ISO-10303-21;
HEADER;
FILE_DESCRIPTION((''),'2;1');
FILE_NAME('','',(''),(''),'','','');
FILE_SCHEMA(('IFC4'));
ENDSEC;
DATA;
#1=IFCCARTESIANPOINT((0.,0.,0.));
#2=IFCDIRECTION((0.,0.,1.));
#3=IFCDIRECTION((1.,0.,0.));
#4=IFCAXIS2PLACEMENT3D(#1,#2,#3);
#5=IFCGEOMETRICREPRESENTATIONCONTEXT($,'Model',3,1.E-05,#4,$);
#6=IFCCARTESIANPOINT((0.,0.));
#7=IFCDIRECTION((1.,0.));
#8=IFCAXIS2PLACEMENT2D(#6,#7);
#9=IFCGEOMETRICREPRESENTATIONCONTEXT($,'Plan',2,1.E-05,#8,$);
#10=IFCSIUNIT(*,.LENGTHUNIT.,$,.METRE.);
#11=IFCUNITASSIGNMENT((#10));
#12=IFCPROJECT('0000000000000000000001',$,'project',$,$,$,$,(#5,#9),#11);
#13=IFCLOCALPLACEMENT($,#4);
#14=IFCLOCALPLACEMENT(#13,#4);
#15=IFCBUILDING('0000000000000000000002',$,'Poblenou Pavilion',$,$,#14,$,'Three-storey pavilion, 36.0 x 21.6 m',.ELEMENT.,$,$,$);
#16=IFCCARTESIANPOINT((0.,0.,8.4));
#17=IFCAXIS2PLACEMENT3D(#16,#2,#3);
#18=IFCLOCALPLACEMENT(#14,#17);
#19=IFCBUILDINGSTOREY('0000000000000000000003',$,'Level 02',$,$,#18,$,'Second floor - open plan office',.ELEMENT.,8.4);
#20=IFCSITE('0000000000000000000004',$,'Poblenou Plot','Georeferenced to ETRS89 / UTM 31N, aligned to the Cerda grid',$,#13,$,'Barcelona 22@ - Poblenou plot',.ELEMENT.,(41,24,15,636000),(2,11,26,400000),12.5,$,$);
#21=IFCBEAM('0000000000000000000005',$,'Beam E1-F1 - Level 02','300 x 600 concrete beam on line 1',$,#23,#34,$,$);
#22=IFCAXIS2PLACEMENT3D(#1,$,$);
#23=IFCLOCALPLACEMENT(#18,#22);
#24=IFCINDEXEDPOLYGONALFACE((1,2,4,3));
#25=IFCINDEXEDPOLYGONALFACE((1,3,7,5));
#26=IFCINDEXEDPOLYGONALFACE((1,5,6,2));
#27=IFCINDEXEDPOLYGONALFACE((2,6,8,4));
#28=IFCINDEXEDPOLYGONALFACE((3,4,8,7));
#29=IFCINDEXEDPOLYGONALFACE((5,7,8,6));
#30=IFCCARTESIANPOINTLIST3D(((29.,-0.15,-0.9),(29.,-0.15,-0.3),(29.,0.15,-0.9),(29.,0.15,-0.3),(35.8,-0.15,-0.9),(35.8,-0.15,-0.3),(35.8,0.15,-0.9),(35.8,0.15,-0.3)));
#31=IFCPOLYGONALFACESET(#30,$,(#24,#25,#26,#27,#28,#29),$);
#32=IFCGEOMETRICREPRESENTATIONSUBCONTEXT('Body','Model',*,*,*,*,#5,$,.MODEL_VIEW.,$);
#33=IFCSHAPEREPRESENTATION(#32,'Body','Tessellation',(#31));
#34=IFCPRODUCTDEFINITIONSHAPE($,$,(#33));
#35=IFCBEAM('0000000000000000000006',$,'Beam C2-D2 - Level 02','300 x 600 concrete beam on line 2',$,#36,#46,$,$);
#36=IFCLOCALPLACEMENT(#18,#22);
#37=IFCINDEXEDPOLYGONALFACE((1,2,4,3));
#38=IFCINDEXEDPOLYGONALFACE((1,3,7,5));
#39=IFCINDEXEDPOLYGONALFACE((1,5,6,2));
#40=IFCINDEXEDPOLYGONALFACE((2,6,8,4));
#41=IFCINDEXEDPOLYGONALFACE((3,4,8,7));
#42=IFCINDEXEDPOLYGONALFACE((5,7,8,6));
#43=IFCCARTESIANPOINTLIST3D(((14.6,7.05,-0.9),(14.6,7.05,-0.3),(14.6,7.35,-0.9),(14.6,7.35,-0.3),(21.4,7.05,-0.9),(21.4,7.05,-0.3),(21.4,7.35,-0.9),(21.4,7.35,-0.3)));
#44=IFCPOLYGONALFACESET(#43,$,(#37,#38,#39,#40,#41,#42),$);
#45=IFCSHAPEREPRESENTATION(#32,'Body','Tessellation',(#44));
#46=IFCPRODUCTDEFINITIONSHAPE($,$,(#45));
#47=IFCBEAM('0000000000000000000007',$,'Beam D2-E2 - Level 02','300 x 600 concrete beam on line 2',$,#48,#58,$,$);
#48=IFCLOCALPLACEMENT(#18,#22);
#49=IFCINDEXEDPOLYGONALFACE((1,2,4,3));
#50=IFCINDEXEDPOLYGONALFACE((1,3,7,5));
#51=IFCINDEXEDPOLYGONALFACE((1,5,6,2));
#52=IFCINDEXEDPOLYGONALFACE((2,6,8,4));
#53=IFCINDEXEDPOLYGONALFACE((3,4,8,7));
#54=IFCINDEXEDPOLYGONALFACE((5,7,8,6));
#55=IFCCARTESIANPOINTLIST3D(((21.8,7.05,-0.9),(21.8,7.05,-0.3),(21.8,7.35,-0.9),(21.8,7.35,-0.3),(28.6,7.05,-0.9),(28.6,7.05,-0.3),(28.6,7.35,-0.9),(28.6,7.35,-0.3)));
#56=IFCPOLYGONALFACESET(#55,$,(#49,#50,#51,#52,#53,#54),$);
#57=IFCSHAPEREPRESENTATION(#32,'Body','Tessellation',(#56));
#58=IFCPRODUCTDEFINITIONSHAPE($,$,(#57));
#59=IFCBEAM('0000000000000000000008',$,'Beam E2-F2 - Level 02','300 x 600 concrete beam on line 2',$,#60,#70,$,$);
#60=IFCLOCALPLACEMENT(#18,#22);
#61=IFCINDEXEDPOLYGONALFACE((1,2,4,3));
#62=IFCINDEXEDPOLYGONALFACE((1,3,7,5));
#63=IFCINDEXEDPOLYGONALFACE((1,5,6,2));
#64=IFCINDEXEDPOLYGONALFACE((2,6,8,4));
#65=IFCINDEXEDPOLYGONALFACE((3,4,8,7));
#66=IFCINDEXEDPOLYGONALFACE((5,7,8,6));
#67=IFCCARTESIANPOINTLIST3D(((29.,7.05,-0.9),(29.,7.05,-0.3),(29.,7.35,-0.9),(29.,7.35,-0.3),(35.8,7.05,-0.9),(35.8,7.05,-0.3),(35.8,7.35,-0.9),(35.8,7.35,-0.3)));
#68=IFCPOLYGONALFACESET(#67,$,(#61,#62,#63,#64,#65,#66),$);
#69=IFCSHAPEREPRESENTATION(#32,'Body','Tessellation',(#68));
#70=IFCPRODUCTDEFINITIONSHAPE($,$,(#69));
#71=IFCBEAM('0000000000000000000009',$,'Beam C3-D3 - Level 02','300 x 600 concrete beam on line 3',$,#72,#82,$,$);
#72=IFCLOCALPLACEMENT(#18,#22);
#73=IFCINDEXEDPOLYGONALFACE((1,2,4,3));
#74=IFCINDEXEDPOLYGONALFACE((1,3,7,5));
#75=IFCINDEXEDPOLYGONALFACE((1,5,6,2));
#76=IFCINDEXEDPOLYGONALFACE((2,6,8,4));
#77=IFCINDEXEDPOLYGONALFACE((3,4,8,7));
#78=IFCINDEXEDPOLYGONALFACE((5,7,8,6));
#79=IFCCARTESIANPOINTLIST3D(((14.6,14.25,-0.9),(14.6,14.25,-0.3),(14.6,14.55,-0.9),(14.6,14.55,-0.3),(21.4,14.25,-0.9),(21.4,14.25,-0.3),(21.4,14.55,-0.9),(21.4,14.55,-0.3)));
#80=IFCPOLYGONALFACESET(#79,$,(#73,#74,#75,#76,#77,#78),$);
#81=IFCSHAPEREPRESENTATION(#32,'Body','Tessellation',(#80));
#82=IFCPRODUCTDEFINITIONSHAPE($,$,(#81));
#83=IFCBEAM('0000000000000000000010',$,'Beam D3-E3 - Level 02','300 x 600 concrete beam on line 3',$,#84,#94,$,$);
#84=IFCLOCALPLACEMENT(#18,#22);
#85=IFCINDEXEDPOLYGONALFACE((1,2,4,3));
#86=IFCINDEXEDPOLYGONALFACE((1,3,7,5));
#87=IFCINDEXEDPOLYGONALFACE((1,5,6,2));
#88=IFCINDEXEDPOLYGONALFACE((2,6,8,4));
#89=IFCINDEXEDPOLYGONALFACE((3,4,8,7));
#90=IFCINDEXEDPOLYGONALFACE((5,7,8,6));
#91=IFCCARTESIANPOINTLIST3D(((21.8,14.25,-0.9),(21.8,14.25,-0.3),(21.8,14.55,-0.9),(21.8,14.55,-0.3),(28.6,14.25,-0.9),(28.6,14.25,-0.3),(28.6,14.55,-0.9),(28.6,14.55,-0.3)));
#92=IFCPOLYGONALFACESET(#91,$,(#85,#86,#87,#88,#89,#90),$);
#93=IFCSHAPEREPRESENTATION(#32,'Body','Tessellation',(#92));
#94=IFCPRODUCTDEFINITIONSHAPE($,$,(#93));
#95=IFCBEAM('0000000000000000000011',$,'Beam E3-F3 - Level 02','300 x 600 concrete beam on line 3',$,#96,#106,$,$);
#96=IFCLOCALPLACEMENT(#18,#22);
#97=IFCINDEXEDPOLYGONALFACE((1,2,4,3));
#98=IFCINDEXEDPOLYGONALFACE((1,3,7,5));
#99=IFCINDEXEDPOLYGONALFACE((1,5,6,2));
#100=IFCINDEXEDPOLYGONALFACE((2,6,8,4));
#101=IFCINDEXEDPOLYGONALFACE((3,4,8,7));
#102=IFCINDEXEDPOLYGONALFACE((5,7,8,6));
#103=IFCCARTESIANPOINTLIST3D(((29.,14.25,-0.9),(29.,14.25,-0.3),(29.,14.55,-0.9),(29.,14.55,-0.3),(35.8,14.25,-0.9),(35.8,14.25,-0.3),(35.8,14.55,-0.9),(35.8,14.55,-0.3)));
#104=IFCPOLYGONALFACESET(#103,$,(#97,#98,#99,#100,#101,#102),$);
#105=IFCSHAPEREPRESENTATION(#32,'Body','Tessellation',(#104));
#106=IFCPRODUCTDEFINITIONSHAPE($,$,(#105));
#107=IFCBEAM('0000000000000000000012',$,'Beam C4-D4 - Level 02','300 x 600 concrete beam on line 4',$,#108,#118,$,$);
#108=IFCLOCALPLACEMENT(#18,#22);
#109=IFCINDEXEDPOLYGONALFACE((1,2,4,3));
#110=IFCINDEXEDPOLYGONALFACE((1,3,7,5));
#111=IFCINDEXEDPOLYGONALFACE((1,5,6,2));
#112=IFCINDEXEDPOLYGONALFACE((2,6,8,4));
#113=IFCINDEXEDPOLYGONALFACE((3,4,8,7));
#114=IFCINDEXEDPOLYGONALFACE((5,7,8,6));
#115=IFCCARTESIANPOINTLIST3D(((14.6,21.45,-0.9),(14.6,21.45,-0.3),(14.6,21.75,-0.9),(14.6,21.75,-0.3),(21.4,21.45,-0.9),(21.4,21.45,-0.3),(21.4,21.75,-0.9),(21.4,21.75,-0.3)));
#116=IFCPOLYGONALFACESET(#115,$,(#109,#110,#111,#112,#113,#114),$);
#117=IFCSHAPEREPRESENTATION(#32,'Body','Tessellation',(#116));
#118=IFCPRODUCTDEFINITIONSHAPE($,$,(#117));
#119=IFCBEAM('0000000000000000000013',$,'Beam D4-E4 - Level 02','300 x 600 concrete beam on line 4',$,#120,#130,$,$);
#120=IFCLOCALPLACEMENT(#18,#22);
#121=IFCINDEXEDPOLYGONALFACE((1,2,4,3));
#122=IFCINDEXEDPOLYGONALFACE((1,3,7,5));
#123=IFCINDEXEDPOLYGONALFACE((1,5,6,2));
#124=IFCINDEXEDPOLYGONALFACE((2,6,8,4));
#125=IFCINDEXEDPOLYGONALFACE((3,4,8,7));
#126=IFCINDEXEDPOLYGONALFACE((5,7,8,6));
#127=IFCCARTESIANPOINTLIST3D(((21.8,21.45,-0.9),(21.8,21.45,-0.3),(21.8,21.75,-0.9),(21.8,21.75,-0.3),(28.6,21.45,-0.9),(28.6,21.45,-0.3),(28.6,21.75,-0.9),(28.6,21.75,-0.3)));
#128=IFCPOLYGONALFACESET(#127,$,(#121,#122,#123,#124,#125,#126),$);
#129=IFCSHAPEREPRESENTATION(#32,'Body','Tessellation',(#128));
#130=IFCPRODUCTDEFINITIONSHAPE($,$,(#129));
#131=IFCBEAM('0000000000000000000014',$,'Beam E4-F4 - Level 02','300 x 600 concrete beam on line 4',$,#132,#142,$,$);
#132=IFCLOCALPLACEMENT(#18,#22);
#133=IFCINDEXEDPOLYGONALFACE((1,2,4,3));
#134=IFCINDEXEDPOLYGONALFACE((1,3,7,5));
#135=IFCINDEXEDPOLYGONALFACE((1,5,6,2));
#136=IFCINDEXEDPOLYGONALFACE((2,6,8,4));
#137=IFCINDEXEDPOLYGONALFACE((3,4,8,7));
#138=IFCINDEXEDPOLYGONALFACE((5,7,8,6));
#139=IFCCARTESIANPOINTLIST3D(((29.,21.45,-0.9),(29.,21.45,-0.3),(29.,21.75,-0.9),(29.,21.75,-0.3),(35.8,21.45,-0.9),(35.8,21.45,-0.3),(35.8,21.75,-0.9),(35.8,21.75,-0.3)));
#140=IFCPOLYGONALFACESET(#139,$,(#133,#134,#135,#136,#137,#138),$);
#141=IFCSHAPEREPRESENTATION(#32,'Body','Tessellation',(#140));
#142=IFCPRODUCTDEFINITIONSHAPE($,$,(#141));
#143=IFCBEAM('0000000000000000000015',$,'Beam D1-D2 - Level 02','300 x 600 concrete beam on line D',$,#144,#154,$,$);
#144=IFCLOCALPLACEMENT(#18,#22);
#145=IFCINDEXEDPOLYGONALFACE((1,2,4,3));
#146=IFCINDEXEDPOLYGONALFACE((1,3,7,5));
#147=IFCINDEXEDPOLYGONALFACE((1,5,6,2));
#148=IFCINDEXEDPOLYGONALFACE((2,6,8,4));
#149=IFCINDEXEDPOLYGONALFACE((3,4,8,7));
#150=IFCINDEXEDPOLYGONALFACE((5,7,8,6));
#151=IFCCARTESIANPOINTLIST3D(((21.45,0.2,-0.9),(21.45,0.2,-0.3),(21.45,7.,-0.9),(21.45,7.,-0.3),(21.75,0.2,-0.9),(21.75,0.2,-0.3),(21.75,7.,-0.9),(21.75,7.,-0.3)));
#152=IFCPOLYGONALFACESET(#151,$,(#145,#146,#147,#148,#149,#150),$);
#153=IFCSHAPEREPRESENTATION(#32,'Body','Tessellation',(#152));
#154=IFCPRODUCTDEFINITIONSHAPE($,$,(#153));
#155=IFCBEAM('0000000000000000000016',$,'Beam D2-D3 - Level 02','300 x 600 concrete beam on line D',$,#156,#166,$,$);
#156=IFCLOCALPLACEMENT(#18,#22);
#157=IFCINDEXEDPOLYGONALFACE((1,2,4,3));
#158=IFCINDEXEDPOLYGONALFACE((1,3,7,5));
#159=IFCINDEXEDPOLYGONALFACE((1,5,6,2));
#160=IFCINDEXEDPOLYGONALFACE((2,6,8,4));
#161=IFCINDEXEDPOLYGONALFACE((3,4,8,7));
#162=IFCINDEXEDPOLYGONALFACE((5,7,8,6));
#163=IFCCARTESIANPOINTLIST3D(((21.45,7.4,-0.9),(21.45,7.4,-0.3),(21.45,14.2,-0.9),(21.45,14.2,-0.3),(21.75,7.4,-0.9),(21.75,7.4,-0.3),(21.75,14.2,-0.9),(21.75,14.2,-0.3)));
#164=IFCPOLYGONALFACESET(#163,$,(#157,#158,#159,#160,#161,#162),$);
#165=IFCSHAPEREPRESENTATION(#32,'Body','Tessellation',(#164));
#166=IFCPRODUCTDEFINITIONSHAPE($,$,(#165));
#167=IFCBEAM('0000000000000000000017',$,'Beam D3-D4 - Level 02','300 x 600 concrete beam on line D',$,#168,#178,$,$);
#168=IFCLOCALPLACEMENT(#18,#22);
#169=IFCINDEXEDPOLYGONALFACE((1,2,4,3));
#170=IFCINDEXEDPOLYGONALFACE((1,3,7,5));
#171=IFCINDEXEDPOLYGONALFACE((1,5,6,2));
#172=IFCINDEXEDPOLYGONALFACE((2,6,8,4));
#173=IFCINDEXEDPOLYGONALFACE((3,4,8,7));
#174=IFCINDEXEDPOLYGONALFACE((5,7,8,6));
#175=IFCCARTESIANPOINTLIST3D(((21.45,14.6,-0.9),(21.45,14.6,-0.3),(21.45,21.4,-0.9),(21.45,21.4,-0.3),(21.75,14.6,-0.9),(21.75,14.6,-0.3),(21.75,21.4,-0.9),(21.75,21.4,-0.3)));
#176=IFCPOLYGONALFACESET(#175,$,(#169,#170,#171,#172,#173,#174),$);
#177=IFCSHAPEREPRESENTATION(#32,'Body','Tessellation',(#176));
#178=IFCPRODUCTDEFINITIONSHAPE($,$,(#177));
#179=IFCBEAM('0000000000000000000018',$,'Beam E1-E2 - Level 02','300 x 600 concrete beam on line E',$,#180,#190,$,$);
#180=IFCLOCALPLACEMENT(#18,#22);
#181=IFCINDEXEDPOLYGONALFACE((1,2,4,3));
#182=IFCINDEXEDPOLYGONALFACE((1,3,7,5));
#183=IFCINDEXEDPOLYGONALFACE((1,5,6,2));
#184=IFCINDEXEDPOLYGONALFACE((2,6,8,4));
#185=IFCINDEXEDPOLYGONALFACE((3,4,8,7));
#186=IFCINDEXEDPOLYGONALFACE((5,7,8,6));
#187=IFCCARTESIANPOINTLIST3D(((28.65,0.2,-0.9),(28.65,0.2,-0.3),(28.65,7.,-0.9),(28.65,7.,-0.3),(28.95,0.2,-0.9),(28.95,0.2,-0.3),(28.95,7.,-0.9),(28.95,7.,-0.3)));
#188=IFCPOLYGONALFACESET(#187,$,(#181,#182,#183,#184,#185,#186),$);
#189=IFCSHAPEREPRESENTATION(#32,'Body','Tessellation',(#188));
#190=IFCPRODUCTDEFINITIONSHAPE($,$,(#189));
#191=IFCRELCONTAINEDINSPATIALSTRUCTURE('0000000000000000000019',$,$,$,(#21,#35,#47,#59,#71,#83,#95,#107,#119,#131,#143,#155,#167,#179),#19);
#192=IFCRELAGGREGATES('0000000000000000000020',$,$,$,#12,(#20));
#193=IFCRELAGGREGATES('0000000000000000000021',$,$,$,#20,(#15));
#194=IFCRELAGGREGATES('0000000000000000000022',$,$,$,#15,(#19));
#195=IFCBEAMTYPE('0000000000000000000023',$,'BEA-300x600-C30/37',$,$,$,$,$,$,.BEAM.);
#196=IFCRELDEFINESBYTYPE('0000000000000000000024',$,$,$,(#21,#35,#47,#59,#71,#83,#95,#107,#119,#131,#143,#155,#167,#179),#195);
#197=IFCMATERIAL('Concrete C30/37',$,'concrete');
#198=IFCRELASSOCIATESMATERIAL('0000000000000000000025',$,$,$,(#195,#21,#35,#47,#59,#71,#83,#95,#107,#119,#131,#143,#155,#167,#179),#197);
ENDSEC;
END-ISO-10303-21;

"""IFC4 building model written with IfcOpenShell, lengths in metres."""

from ifc_helpers import new_model, si_unit, frame, origin_with_axes, origin_2d_with_axis, place, context, subcontext, project, spatial, line, indexed_curve, rectangle, outline, extrude, material, material_profile, profile_set, profile_usage, type_object, element, save


model = new_model("IFC4")

# Units and contexts
model_context = context("Model", 3, precision=1e-05, world=origin_with_axes())
plan_context = context("Plan", 2, precision=1e-05, world=origin_2d_with_axis())
body_context = subcontext(model_context, "Body", "Model", "MODEL_VIEW")
ifc_project = project(units=[si_unit("LENGTHUNIT", "METRE")], contexts=[model_context, plan_context])

# Site, building, storey
site_placement = place(None, origin_with_axes())
site = spatial("IfcSite", under=ifc_project, at=site_placement, Name="Poblenou Plot", Description="Georeferenced to ETRS89 / UTM 31N, aligned to the Cerda grid", LongName="Barcelona 22@ - Poblenou plot", CompositionType="ELEMENT", RefLatitude=(41, 24, 15, 636000), RefLongitude=(2, 11, 26, 400000), RefElevation=12.5)
building_placement = place(site_placement, origin_with_axes())
building = spatial("IfcBuilding", under=site, at=building_placement, Name="Poblenou Pavilion", LongName="Three-storey pavilion, 36.0 x 21.6 m", CompositionType="ELEMENT")
storey_placement = place(building_placement, frame((0.0, 0.0, 8.4), z_axis=(0.0, 0.0, 1.0), x_axis=(1.0, 0.0, 0.0)))
storey = spatial("IfcBuildingStorey", under=building, at=storey_placement, Name="Level 02", LongName="Second floor - open plan office", CompositionType="ELEMENT", Elevation=8.4)

# Shared definitions
ifc_material = material(Name="Concrete C30/37", Category="concrete")

# Beams
ifc_material_profile_1 = material_profile(ifc_material, rectangle(XDim=0.3, YDim=0.6))
ifc_profile_set_1 = profile_set([ifc_material_profile_1], Name="BEA-300x600-C30/37")
beam_type = type_object("IfcBeamType", Name="BEA-300x600-C30/37", PredefinedType="BEAM", material=ifc_profile_set_1)
ifc_profile_usage_1 = profile_usage(ifc_profile_set_1)
beam_1_placement = place(storey_placement, frame((29.0, -0.15, -0.9), z_axis=(1.0, 0.0, 0.0), x_axis=(0.0, 1.0, 0.0)))
element("IfcBeam", 1, at=beam_1_placement, inside=storey, type_object=beam_type, material=ifc_profile_usage_1, Name="Beam E1-F1 - Level 02", Description="300 x 600 concrete beam on line 1", context=body_context, shape_type="SweptSolid", body=[
    extrude(outline(indexed_curve([(0.0, 0.0), (0.3, 0.0), (0.3, 0.6), (0.0, 0.6)], segments=[line(1, 2, 3, 4, 1)])), origin_with_axes(), (0.0, 0.0, 1.0), 6.8),
])
ifc_profile_usage_2 = profile_usage(ifc_profile_set_1)
beam_2_placement = place(storey_placement, frame((14.6, 7.05, -0.9), z_axis=(1.0, 0.0, 0.0), x_axis=(0.0, 1.0, 0.0)))
element("IfcBeam", 2, at=beam_2_placement, inside=storey, type_object=beam_type, material=ifc_profile_usage_2, Name="Beam C2-D2 - Level 02", Description="300 x 600 concrete beam on line 2", context=body_context, shape_type="SweptSolid", body=[
    extrude(outline(indexed_curve([(0.0, 0.0), (0.3, 0.0), (0.3, 0.6), (0.0, 0.6)], segments=[line(1, 2, 3, 4, 1)])), origin_with_axes(), (0.0, 0.0, 1.0), 6.8),
])
ifc_profile_usage_3 = profile_usage(ifc_profile_set_1)
beam_3_placement = place(storey_placement, frame((21.8, 7.05, -0.9), z_axis=(1.0, 0.0, 0.0), x_axis=(0.0, 1.0, 0.0)))
element("IfcBeam", 3, at=beam_3_placement, inside=storey, type_object=beam_type, material=ifc_profile_usage_3, Name="Beam D2-E2 - Level 02", Description="300 x 600 concrete beam on line 2", context=body_context, shape_type="SweptSolid", body=[
    extrude(outline(indexed_curve([(0.0, 0.0), (0.3, 0.0), (0.3, 0.6), (0.0, 0.6)], segments=[line(1, 2, 3, 4, 1)])), origin_with_axes(), (0.0, 0.0, 1.0), 6.8),
])
ifc_profile_usage_4 = profile_usage(ifc_profile_set_1)
beam_4_placement = place(storey_placement, frame((29.0, 7.05, -0.9), z_axis=(1.0, 0.0, 0.0), x_axis=(0.0, 1.0, 0.0)))
element("IfcBeam", 4, at=beam_4_placement, inside=storey, type_object=beam_type, material=ifc_profile_usage_4, Name="Beam E2-F2 - Level 02", Description="300 x 600 concrete beam on line 2", context=body_context, shape_type="SweptSolid", body=[
    extrude(outline(indexed_curve([(0.0, 0.0), (0.3, 0.0), (0.3, 0.6), (0.0, 0.6)], segments=[line(1, 2, 3, 4, 1)])), origin_with_axes(), (0.0, 0.0, 1.0), 6.8),
])
ifc_profile_usage_5 = profile_usage(ifc_profile_set_1)
beam_5_placement = place(storey_placement, frame((14.6, 14.25, -0.9), z_axis=(1.0, 0.0, 0.0), x_axis=(0.0, 1.0, 0.0)))
element("IfcBeam", 5, at=beam_5_placement, inside=storey, type_object=beam_type, material=ifc_profile_usage_5, Name="Beam C3-D3 - Level 02", Description="300 x 600 concrete beam on line 3", context=body_context, shape_type="SweptSolid", body=[
    extrude(outline(indexed_curve([(0.0, 0.0), (0.3, 0.0), (0.3, 0.6), (0.0, 0.6)], segments=[line(1, 2, 3, 4, 1)])), origin_with_axes(), (0.0, 0.0, 1.0), 6.8),
])
ifc_profile_usage_6 = profile_usage(ifc_profile_set_1)
beam_6_placement = place(storey_placement, frame((21.8, 14.25, -0.9), z_axis=(1.0, 0.0, 0.0), x_axis=(0.0, 1.0, 0.0)))
element("IfcBeam", 6, at=beam_6_placement, inside=storey, type_object=beam_type, material=ifc_profile_usage_6, Name="Beam D3-E3 - Level 02", Description="300 x 600 concrete beam on line 3", context=body_context, shape_type="SweptSolid", body=[
    extrude(outline(indexed_curve([(0.0, 0.0), (0.3, 0.0), (0.3, 0.6), (0.0, 0.6)], segments=[line(1, 2, 3, 4, 1)])), origin_with_axes(), (0.0, 0.0, 1.0), 6.8),
])
ifc_profile_usage_7 = profile_usage(ifc_profile_set_1)
beam_7_placement = place(storey_placement, frame((29.0, 14.25, -0.9), z_axis=(1.0, 0.0, 0.0), x_axis=(0.0, 1.0, 0.0)))
element("IfcBeam", 7, at=beam_7_placement, inside=storey, type_object=beam_type, material=ifc_profile_usage_7, Name="Beam E3-F3 - Level 02", Description="300 x 600 concrete beam on line 3", context=body_context, shape_type="SweptSolid", body=[
    extrude(outline(indexed_curve([(0.0, 0.0), (0.3, 0.0), (0.3, 0.6), (0.0, 0.6)], segments=[line(1, 2, 3, 4, 1)])), origin_with_axes(), (0.0, 0.0, 1.0), 6.8),
])
ifc_profile_usage_8 = profile_usage(ifc_profile_set_1)
beam_8_placement = place(storey_placement, frame((14.6, 21.45, -0.9), z_axis=(1.0, 0.0, 0.0), x_axis=(0.0, 1.0, 0.0)))
element("IfcBeam", 8, at=beam_8_placement, inside=storey, type_object=beam_type, material=ifc_profile_usage_8, Name="Beam C4-D4 - Level 02", Description="300 x 600 concrete beam on line 4", context=body_context, shape_type="SweptSolid", body=[
    extrude(outline(indexed_curve([(0.0, 0.0), (0.3, 0.0), (0.3, 0.6), (0.0, 0.6)], segments=[line(1, 2, 3, 4, 1)])), origin_with_axes(), (0.0, 0.0, 1.0), 6.8),
])
ifc_profile_usage_9 = profile_usage(ifc_profile_set_1)
beam_9_placement = place(storey_placement, frame((21.8, 21.45, -0.9), z_axis=(1.0, 0.0, 0.0), x_axis=(0.0, 1.0, 0.0)))
element("IfcBeam", 9, at=beam_9_placement, inside=storey, type_object=beam_type, material=ifc_profile_usage_9, Name="Beam D4-E4 - Level 02", Description="300 x 600 concrete beam on line 4", context=body_context, shape_type="SweptSolid", body=[
    extrude(outline(indexed_curve([(0.0, 0.0), (0.3, 0.0), (0.3, 0.6), (0.0, 0.6)], segments=[line(1, 2, 3, 4, 1)])), origin_with_axes(), (0.0, 0.0, 1.0), 6.8),
])
ifc_profile_usage_10 = profile_usage(ifc_profile_set_1)
beam_10_placement = place(storey_placement, frame((29.0, 21.45, -0.9), z_axis=(1.0, 0.0, 0.0), x_axis=(0.0, 1.0, 0.0)))
element("IfcBeam", 10, at=beam_10_placement, inside=storey, type_object=beam_type, material=ifc_profile_usage_10, Name="Beam E4-F4 - Level 02", Description="300 x 600 concrete beam on line 4", context=body_context, shape_type="SweptSolid", body=[
    extrude(outline(indexed_curve([(0.0, 0.0), (0.3, 0.0), (0.3, 0.6), (0.0, 0.6)], segments=[line(1, 2, 3, 4, 1)])), origin_with_axes(), (0.0, 0.0, 1.0), 6.8),
])
ifc_profile_usage_11 = profile_usage(ifc_profile_set_1)
beam_11_placement = place(storey_placement, frame((21.45, 0.2, -0.9), z_axis=(0.0, 1.0, 0.0), x_axis=(0.0, 0.0, 1.0)))
element("IfcBeam", 11, at=beam_11_placement, inside=storey, type_object=beam_type, material=ifc_profile_usage_11, Name="Beam D1-D2 - Level 02", Description="300 x 600 concrete beam on line D", context=body_context, shape_type="SweptSolid", body=[
    extrude(outline(indexed_curve([(0.0, 0.0), (0.6, 0.0), (0.6, 0.3), (0.0, 0.3)], segments=[line(1, 2, 3, 4, 1)])), origin_with_axes(), (0.0, 0.0, 1.0), 6.8),
])
ifc_profile_usage_12 = profile_usage(ifc_profile_set_1)
beam_12_placement = place(storey_placement, frame((21.45, 7.4, -0.9), z_axis=(0.0, 1.0, 0.0), x_axis=(0.0, 0.0, 1.0)))
element("IfcBeam", 12, at=beam_12_placement, inside=storey, type_object=beam_type, material=ifc_profile_usage_12, Name="Beam D2-D3 - Level 02", Description="300 x 600 concrete beam on line D", context=body_context, shape_type="SweptSolid", body=[
    extrude(outline(indexed_curve([(0.0, 0.0), (0.6, 0.0), (0.6, 0.3), (0.0, 0.3)], segments=[line(1, 2, 3, 4, 1)])), origin_with_axes(), (0.0, 0.0, 1.0), 6.8),
])
ifc_profile_usage_13 = profile_usage(ifc_profile_set_1)
beam_13_placement = place(storey_placement, frame((21.45, 14.6, -0.9), z_axis=(0.0, 1.0, 0.0), x_axis=(0.0, 0.0, 1.0)))
element("IfcBeam", 13, at=beam_13_placement, inside=storey, type_object=beam_type, material=ifc_profile_usage_13, Name="Beam D3-D4 - Level 02", Description="300 x 600 concrete beam on line D", context=body_context, shape_type="SweptSolid", body=[
    extrude(outline(indexed_curve([(0.0, 0.0), (0.6, 0.0), (0.6, 0.3), (0.0, 0.3)], segments=[line(1, 2, 3, 4, 1)])), origin_with_axes(), (0.0, 0.0, 1.0), 6.8),
])
ifc_profile_usage_14 = profile_usage(ifc_profile_set_1)
beam_14_placement = place(storey_placement, frame((28.65, 0.2, -0.9), z_axis=(0.0, 1.0, 0.0), x_axis=(0.0, 0.0, 1.0)))
element("IfcBeam", 14, at=beam_14_placement, inside=storey, type_object=beam_type, material=ifc_profile_usage_14, Name="Beam E1-E2 - Level 02", Description="300 x 600 concrete beam on line E", context=body_context, shape_type="SweptSolid", body=[
    extrude(outline(indexed_curve([(0.0, 0.0), (0.6, 0.0), (0.6, 0.3), (0.0, 0.3)], segments=[line(1, 2, 3, 4, 1)])), origin_with_axes(), (0.0, 0.0, 1.0), 6.8),
])

save(model, "model.ifc")
